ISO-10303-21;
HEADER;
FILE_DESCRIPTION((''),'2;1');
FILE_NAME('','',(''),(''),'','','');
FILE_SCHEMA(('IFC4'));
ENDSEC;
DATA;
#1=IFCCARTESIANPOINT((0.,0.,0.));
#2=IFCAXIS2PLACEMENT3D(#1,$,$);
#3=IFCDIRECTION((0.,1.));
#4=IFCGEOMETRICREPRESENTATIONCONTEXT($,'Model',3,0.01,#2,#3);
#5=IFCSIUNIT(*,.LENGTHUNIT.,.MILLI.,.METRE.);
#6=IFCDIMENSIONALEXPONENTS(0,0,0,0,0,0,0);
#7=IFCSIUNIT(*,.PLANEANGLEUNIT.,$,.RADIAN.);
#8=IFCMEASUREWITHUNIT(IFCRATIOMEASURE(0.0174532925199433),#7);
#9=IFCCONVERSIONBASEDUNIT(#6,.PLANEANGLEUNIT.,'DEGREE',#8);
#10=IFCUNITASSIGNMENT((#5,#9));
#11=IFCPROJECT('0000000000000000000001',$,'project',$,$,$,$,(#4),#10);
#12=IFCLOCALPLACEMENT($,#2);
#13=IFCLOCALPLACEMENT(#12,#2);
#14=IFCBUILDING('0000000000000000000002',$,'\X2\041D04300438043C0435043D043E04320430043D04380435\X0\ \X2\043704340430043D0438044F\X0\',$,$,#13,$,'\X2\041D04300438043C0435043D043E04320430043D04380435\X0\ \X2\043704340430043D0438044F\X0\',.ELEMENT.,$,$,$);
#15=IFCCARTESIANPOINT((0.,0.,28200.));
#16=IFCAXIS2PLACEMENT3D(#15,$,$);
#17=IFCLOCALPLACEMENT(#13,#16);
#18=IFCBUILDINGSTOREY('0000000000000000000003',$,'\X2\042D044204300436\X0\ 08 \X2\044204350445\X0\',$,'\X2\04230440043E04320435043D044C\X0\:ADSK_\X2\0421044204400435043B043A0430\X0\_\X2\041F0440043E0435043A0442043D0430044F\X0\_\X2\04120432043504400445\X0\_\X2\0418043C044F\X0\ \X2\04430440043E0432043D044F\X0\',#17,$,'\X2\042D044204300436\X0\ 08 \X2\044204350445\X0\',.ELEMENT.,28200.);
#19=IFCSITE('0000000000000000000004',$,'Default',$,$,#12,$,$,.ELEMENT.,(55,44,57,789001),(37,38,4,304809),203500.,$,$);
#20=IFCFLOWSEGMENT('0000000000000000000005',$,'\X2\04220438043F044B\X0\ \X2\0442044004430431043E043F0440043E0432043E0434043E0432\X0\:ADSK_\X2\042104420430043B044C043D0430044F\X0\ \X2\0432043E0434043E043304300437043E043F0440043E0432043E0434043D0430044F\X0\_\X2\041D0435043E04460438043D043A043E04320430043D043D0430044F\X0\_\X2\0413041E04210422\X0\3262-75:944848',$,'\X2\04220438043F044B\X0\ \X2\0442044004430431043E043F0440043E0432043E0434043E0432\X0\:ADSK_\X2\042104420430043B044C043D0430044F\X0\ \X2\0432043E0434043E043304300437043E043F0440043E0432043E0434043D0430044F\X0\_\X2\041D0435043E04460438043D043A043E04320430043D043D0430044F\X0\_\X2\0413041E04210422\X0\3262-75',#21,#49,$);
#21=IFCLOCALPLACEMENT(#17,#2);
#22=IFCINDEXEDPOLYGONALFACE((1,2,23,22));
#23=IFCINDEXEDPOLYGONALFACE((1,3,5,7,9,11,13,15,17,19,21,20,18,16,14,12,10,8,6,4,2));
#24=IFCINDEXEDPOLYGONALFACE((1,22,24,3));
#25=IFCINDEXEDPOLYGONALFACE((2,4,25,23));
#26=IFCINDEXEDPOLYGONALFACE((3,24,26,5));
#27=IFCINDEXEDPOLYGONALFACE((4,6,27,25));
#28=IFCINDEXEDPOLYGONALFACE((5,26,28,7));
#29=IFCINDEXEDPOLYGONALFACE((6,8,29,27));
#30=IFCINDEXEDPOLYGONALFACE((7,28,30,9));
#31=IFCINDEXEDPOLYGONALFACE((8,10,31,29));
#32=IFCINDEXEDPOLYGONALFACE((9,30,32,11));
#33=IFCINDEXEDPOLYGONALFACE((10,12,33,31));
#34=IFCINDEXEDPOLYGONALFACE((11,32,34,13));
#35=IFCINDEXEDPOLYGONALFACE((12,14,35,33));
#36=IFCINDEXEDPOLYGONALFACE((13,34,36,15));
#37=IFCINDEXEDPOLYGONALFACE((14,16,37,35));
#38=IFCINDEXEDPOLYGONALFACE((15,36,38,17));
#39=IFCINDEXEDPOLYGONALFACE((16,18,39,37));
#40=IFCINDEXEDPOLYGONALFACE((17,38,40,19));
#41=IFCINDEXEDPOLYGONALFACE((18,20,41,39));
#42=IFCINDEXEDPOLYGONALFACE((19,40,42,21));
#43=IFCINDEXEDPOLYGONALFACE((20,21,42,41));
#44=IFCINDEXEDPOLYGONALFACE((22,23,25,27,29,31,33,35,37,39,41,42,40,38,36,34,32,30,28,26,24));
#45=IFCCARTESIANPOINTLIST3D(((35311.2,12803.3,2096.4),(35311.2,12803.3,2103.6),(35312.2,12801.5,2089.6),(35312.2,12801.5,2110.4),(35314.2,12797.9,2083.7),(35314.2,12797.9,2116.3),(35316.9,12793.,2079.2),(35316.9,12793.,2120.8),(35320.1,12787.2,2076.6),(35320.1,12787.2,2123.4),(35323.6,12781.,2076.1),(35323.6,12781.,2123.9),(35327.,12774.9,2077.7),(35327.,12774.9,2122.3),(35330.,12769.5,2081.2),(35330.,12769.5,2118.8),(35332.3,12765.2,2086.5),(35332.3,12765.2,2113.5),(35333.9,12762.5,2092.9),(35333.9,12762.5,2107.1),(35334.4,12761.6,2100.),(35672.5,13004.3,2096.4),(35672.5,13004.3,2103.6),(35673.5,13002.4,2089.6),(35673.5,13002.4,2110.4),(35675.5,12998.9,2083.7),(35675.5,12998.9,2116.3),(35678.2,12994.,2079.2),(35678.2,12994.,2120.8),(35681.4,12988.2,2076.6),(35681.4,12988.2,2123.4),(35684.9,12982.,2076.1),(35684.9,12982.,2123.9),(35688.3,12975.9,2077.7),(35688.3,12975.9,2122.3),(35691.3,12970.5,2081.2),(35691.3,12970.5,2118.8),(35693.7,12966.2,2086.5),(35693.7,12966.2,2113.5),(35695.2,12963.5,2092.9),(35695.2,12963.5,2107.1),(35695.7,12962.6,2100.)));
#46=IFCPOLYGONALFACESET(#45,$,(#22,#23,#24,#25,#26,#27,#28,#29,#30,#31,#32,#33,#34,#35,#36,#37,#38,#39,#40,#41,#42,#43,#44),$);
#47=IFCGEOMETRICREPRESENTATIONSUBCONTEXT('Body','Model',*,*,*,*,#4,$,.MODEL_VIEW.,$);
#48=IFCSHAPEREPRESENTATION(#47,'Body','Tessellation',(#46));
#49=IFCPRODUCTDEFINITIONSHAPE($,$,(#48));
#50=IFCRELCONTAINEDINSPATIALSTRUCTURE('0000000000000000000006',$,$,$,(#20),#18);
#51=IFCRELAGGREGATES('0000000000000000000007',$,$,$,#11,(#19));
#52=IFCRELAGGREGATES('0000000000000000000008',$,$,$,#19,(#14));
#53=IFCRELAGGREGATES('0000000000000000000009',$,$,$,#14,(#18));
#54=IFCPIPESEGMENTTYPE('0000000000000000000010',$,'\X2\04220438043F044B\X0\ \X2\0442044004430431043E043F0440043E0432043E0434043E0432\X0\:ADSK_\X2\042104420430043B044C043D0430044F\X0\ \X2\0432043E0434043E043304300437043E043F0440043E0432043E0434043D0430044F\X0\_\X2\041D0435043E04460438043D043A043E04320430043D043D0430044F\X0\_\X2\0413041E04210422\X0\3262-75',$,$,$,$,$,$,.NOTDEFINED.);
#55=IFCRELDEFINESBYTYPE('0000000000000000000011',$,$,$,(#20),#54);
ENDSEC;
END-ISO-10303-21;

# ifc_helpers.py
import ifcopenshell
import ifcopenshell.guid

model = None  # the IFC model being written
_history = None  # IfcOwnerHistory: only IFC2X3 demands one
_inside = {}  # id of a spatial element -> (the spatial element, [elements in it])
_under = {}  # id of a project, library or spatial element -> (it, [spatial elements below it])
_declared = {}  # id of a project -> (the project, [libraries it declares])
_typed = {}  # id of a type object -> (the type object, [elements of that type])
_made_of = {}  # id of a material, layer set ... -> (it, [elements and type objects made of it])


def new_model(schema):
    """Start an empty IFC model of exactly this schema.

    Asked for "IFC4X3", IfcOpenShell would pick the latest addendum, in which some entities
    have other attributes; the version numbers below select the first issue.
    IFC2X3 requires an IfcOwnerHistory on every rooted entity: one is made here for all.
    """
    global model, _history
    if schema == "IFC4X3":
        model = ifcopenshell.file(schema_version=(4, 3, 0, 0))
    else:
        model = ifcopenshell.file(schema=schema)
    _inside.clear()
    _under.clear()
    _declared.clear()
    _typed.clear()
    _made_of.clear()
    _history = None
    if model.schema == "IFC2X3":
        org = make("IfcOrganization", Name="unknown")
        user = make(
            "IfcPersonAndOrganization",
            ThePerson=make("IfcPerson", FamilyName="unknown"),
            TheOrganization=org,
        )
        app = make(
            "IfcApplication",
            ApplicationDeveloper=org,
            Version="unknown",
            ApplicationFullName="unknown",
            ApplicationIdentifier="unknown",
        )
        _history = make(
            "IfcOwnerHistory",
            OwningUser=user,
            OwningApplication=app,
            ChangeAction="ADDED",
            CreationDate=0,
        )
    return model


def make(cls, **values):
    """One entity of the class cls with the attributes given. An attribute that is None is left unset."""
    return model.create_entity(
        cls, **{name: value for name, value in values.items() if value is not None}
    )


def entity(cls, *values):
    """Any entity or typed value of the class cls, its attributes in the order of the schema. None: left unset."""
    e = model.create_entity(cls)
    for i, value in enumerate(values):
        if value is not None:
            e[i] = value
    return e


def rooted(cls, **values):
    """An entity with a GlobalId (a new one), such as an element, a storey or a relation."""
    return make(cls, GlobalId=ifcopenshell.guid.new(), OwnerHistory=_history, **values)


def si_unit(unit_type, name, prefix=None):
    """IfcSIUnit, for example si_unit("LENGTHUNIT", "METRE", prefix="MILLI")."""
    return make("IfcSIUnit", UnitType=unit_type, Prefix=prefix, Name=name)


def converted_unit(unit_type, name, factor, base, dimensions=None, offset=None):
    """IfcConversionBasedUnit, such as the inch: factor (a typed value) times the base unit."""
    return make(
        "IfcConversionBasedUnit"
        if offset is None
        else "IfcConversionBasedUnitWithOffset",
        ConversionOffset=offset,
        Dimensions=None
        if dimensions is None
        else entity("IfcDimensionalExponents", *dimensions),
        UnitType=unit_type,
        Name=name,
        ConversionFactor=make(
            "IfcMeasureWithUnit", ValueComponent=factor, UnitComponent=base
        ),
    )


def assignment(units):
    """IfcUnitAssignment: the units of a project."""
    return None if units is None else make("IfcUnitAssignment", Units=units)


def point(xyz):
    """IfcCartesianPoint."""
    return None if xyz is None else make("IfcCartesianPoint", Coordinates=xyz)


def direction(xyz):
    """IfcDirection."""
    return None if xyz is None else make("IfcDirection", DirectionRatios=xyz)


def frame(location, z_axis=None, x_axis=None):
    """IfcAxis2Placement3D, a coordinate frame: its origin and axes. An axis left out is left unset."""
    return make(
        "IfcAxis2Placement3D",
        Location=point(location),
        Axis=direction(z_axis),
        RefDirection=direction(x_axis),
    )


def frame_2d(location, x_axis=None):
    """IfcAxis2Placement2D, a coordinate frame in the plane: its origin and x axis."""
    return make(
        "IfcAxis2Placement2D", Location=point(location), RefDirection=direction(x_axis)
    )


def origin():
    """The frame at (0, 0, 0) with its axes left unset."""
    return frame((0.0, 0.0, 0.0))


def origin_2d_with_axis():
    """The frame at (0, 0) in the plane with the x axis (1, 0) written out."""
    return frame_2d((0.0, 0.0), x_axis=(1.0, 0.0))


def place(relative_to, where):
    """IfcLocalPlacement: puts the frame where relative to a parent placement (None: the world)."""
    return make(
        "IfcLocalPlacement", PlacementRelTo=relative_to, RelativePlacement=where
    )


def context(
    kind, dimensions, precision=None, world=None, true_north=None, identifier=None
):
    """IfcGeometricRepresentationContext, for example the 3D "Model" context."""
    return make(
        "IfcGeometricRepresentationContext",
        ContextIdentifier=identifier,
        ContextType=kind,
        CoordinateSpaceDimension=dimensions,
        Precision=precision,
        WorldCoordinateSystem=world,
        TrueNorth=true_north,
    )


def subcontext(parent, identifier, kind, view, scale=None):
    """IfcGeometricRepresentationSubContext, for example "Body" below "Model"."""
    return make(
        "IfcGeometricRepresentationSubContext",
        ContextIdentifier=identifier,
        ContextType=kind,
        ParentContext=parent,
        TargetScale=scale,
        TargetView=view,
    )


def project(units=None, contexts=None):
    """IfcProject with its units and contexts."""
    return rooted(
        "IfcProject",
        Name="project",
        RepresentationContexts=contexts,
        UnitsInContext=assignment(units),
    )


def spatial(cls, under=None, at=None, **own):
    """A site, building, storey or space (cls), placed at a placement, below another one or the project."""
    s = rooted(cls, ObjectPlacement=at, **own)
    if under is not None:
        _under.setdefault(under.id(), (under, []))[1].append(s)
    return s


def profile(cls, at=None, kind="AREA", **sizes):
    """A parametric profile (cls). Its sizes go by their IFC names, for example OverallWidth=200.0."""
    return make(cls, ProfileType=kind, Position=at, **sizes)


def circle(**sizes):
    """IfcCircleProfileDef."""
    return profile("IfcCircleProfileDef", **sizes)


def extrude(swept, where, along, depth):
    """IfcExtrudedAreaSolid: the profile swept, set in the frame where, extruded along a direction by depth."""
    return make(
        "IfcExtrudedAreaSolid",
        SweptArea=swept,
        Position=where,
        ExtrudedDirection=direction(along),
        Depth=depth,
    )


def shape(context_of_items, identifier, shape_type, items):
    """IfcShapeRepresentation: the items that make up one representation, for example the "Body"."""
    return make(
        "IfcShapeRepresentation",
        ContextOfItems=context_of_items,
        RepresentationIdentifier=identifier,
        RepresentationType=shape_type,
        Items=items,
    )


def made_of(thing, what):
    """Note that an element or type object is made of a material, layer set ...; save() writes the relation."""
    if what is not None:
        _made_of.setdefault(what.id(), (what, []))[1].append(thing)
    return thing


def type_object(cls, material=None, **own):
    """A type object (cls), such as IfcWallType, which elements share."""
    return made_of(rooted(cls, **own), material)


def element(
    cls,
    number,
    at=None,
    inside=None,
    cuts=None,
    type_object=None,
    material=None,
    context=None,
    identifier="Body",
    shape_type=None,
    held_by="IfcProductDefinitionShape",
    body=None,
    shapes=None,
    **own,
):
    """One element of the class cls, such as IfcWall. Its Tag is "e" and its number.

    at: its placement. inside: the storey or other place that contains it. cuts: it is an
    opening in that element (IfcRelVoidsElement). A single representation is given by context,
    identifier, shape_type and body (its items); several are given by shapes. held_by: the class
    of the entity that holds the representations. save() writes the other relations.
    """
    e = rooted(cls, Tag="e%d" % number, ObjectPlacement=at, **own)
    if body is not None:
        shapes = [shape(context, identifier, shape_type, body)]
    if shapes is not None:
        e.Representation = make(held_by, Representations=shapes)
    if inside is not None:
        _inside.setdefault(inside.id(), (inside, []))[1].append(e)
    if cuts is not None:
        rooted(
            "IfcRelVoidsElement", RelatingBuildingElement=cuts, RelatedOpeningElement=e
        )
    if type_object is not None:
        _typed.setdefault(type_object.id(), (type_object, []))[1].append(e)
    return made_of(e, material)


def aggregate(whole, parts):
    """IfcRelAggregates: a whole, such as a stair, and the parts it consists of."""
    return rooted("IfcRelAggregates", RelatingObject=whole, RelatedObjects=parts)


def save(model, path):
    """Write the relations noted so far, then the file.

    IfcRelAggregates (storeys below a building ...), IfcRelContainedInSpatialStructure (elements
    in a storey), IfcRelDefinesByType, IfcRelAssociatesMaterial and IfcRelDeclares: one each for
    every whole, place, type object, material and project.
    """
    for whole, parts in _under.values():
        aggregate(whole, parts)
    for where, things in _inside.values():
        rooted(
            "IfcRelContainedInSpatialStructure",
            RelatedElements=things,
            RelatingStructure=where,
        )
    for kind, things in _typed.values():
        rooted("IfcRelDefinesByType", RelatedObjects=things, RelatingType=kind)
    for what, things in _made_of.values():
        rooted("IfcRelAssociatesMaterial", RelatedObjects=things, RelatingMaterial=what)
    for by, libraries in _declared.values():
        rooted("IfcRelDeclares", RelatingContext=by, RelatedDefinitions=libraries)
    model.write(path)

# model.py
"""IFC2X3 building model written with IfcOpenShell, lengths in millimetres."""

from ifc_helpers import new_model, entity, si_unit, converted_unit, direction, frame, origin, origin_2d_with_axis, place, context, subcontext, project, spatial, circle, extrude, type_object, element, save


model = new_model("IFC2X3")

# Units and contexts
model_context = context("Model", 3, precision=0.01, world=origin(), true_north=direction((0.0, 1.0)))
body_context = subcontext(model_context, "Body", "Model", "MODEL_VIEW")
ifc_project = project(units=[si_unit("LENGTHUNIT", "METRE", prefix="MILLI"), converted_unit("PLANEANGLEUNIT", "DEGREE", entity("IfcRatioMeasure", 0.0174532925199433), si_unit("PLANEANGLEUNIT", "RADIAN"), dimensions=[0, 0, 0, 0, 0, 0, 0])], contexts=[model_context])

# Site, building, storey
site_placement = place(None, origin())
site = spatial("IfcSite", under=ifc_project, at=site_placement, Name="Default", CompositionType="ELEMENT", RefLatitude=(55, 44, 57, 789001), RefLongitude=(37, 38, 4, 304809), RefElevation=203500.0)
building_placement = place(site_placement, origin())
building = spatial("IfcBuilding", under=site, at=building_placement, Name="Наименование здания", LongName="Наименование здания", CompositionType="ELEMENT")
storey_placement = place(building_placement, frame((0.0, 0.0, 28200.0)))
storey = spatial("IfcBuildingStorey", under=building, at=storey_placement, Name="Этаж 08 тех", ObjectType="Уровень:ADSK_Стрелка_Проектная_Вверх_Имя уровня", LongName="Этаж 08 тех", CompositionType="ELEMENT", Elevation=28200.0)

# Flow segment
pipe_segment_type = type_object("IfcPipeSegmentType", Name="Типы трубопроводов:ADSK_Стальная водогазопроводная_Неоцинкованная_ГОСТ3262-75", PredefinedType="NOTDEFINED")
flow_segment_1_placement = place(storey_placement, frame((35309.4, 12760.0, 2074.4)))
element("IfcFlowSegment", 1, at=flow_segment_1_placement, inside=storey, type_object=pipe_segment_type, Name="Типы трубопроводов:ADSK_Стальная водогазопроводная_Неоцинкованная_ГОСТ3262-75:944848", ObjectType="Типы трубопроводов:ADSK_Стальная водогазопроводная_Неоцинкованная_ГОСТ3262-75", context=body_context, shape_type="SweptSolid", body=[
    extrude(circle(Radius=24.0, at=origin_2d_with_axis()), frame((13.3, 22.6, 25.6), z_axis=(0.873901, 0.486104, 0.0), x_axis=(0.486104, -0.873901, 0.0)), (0.0, 0.0, 1.0), 413.4),
])

save(model, "model.ifc")
